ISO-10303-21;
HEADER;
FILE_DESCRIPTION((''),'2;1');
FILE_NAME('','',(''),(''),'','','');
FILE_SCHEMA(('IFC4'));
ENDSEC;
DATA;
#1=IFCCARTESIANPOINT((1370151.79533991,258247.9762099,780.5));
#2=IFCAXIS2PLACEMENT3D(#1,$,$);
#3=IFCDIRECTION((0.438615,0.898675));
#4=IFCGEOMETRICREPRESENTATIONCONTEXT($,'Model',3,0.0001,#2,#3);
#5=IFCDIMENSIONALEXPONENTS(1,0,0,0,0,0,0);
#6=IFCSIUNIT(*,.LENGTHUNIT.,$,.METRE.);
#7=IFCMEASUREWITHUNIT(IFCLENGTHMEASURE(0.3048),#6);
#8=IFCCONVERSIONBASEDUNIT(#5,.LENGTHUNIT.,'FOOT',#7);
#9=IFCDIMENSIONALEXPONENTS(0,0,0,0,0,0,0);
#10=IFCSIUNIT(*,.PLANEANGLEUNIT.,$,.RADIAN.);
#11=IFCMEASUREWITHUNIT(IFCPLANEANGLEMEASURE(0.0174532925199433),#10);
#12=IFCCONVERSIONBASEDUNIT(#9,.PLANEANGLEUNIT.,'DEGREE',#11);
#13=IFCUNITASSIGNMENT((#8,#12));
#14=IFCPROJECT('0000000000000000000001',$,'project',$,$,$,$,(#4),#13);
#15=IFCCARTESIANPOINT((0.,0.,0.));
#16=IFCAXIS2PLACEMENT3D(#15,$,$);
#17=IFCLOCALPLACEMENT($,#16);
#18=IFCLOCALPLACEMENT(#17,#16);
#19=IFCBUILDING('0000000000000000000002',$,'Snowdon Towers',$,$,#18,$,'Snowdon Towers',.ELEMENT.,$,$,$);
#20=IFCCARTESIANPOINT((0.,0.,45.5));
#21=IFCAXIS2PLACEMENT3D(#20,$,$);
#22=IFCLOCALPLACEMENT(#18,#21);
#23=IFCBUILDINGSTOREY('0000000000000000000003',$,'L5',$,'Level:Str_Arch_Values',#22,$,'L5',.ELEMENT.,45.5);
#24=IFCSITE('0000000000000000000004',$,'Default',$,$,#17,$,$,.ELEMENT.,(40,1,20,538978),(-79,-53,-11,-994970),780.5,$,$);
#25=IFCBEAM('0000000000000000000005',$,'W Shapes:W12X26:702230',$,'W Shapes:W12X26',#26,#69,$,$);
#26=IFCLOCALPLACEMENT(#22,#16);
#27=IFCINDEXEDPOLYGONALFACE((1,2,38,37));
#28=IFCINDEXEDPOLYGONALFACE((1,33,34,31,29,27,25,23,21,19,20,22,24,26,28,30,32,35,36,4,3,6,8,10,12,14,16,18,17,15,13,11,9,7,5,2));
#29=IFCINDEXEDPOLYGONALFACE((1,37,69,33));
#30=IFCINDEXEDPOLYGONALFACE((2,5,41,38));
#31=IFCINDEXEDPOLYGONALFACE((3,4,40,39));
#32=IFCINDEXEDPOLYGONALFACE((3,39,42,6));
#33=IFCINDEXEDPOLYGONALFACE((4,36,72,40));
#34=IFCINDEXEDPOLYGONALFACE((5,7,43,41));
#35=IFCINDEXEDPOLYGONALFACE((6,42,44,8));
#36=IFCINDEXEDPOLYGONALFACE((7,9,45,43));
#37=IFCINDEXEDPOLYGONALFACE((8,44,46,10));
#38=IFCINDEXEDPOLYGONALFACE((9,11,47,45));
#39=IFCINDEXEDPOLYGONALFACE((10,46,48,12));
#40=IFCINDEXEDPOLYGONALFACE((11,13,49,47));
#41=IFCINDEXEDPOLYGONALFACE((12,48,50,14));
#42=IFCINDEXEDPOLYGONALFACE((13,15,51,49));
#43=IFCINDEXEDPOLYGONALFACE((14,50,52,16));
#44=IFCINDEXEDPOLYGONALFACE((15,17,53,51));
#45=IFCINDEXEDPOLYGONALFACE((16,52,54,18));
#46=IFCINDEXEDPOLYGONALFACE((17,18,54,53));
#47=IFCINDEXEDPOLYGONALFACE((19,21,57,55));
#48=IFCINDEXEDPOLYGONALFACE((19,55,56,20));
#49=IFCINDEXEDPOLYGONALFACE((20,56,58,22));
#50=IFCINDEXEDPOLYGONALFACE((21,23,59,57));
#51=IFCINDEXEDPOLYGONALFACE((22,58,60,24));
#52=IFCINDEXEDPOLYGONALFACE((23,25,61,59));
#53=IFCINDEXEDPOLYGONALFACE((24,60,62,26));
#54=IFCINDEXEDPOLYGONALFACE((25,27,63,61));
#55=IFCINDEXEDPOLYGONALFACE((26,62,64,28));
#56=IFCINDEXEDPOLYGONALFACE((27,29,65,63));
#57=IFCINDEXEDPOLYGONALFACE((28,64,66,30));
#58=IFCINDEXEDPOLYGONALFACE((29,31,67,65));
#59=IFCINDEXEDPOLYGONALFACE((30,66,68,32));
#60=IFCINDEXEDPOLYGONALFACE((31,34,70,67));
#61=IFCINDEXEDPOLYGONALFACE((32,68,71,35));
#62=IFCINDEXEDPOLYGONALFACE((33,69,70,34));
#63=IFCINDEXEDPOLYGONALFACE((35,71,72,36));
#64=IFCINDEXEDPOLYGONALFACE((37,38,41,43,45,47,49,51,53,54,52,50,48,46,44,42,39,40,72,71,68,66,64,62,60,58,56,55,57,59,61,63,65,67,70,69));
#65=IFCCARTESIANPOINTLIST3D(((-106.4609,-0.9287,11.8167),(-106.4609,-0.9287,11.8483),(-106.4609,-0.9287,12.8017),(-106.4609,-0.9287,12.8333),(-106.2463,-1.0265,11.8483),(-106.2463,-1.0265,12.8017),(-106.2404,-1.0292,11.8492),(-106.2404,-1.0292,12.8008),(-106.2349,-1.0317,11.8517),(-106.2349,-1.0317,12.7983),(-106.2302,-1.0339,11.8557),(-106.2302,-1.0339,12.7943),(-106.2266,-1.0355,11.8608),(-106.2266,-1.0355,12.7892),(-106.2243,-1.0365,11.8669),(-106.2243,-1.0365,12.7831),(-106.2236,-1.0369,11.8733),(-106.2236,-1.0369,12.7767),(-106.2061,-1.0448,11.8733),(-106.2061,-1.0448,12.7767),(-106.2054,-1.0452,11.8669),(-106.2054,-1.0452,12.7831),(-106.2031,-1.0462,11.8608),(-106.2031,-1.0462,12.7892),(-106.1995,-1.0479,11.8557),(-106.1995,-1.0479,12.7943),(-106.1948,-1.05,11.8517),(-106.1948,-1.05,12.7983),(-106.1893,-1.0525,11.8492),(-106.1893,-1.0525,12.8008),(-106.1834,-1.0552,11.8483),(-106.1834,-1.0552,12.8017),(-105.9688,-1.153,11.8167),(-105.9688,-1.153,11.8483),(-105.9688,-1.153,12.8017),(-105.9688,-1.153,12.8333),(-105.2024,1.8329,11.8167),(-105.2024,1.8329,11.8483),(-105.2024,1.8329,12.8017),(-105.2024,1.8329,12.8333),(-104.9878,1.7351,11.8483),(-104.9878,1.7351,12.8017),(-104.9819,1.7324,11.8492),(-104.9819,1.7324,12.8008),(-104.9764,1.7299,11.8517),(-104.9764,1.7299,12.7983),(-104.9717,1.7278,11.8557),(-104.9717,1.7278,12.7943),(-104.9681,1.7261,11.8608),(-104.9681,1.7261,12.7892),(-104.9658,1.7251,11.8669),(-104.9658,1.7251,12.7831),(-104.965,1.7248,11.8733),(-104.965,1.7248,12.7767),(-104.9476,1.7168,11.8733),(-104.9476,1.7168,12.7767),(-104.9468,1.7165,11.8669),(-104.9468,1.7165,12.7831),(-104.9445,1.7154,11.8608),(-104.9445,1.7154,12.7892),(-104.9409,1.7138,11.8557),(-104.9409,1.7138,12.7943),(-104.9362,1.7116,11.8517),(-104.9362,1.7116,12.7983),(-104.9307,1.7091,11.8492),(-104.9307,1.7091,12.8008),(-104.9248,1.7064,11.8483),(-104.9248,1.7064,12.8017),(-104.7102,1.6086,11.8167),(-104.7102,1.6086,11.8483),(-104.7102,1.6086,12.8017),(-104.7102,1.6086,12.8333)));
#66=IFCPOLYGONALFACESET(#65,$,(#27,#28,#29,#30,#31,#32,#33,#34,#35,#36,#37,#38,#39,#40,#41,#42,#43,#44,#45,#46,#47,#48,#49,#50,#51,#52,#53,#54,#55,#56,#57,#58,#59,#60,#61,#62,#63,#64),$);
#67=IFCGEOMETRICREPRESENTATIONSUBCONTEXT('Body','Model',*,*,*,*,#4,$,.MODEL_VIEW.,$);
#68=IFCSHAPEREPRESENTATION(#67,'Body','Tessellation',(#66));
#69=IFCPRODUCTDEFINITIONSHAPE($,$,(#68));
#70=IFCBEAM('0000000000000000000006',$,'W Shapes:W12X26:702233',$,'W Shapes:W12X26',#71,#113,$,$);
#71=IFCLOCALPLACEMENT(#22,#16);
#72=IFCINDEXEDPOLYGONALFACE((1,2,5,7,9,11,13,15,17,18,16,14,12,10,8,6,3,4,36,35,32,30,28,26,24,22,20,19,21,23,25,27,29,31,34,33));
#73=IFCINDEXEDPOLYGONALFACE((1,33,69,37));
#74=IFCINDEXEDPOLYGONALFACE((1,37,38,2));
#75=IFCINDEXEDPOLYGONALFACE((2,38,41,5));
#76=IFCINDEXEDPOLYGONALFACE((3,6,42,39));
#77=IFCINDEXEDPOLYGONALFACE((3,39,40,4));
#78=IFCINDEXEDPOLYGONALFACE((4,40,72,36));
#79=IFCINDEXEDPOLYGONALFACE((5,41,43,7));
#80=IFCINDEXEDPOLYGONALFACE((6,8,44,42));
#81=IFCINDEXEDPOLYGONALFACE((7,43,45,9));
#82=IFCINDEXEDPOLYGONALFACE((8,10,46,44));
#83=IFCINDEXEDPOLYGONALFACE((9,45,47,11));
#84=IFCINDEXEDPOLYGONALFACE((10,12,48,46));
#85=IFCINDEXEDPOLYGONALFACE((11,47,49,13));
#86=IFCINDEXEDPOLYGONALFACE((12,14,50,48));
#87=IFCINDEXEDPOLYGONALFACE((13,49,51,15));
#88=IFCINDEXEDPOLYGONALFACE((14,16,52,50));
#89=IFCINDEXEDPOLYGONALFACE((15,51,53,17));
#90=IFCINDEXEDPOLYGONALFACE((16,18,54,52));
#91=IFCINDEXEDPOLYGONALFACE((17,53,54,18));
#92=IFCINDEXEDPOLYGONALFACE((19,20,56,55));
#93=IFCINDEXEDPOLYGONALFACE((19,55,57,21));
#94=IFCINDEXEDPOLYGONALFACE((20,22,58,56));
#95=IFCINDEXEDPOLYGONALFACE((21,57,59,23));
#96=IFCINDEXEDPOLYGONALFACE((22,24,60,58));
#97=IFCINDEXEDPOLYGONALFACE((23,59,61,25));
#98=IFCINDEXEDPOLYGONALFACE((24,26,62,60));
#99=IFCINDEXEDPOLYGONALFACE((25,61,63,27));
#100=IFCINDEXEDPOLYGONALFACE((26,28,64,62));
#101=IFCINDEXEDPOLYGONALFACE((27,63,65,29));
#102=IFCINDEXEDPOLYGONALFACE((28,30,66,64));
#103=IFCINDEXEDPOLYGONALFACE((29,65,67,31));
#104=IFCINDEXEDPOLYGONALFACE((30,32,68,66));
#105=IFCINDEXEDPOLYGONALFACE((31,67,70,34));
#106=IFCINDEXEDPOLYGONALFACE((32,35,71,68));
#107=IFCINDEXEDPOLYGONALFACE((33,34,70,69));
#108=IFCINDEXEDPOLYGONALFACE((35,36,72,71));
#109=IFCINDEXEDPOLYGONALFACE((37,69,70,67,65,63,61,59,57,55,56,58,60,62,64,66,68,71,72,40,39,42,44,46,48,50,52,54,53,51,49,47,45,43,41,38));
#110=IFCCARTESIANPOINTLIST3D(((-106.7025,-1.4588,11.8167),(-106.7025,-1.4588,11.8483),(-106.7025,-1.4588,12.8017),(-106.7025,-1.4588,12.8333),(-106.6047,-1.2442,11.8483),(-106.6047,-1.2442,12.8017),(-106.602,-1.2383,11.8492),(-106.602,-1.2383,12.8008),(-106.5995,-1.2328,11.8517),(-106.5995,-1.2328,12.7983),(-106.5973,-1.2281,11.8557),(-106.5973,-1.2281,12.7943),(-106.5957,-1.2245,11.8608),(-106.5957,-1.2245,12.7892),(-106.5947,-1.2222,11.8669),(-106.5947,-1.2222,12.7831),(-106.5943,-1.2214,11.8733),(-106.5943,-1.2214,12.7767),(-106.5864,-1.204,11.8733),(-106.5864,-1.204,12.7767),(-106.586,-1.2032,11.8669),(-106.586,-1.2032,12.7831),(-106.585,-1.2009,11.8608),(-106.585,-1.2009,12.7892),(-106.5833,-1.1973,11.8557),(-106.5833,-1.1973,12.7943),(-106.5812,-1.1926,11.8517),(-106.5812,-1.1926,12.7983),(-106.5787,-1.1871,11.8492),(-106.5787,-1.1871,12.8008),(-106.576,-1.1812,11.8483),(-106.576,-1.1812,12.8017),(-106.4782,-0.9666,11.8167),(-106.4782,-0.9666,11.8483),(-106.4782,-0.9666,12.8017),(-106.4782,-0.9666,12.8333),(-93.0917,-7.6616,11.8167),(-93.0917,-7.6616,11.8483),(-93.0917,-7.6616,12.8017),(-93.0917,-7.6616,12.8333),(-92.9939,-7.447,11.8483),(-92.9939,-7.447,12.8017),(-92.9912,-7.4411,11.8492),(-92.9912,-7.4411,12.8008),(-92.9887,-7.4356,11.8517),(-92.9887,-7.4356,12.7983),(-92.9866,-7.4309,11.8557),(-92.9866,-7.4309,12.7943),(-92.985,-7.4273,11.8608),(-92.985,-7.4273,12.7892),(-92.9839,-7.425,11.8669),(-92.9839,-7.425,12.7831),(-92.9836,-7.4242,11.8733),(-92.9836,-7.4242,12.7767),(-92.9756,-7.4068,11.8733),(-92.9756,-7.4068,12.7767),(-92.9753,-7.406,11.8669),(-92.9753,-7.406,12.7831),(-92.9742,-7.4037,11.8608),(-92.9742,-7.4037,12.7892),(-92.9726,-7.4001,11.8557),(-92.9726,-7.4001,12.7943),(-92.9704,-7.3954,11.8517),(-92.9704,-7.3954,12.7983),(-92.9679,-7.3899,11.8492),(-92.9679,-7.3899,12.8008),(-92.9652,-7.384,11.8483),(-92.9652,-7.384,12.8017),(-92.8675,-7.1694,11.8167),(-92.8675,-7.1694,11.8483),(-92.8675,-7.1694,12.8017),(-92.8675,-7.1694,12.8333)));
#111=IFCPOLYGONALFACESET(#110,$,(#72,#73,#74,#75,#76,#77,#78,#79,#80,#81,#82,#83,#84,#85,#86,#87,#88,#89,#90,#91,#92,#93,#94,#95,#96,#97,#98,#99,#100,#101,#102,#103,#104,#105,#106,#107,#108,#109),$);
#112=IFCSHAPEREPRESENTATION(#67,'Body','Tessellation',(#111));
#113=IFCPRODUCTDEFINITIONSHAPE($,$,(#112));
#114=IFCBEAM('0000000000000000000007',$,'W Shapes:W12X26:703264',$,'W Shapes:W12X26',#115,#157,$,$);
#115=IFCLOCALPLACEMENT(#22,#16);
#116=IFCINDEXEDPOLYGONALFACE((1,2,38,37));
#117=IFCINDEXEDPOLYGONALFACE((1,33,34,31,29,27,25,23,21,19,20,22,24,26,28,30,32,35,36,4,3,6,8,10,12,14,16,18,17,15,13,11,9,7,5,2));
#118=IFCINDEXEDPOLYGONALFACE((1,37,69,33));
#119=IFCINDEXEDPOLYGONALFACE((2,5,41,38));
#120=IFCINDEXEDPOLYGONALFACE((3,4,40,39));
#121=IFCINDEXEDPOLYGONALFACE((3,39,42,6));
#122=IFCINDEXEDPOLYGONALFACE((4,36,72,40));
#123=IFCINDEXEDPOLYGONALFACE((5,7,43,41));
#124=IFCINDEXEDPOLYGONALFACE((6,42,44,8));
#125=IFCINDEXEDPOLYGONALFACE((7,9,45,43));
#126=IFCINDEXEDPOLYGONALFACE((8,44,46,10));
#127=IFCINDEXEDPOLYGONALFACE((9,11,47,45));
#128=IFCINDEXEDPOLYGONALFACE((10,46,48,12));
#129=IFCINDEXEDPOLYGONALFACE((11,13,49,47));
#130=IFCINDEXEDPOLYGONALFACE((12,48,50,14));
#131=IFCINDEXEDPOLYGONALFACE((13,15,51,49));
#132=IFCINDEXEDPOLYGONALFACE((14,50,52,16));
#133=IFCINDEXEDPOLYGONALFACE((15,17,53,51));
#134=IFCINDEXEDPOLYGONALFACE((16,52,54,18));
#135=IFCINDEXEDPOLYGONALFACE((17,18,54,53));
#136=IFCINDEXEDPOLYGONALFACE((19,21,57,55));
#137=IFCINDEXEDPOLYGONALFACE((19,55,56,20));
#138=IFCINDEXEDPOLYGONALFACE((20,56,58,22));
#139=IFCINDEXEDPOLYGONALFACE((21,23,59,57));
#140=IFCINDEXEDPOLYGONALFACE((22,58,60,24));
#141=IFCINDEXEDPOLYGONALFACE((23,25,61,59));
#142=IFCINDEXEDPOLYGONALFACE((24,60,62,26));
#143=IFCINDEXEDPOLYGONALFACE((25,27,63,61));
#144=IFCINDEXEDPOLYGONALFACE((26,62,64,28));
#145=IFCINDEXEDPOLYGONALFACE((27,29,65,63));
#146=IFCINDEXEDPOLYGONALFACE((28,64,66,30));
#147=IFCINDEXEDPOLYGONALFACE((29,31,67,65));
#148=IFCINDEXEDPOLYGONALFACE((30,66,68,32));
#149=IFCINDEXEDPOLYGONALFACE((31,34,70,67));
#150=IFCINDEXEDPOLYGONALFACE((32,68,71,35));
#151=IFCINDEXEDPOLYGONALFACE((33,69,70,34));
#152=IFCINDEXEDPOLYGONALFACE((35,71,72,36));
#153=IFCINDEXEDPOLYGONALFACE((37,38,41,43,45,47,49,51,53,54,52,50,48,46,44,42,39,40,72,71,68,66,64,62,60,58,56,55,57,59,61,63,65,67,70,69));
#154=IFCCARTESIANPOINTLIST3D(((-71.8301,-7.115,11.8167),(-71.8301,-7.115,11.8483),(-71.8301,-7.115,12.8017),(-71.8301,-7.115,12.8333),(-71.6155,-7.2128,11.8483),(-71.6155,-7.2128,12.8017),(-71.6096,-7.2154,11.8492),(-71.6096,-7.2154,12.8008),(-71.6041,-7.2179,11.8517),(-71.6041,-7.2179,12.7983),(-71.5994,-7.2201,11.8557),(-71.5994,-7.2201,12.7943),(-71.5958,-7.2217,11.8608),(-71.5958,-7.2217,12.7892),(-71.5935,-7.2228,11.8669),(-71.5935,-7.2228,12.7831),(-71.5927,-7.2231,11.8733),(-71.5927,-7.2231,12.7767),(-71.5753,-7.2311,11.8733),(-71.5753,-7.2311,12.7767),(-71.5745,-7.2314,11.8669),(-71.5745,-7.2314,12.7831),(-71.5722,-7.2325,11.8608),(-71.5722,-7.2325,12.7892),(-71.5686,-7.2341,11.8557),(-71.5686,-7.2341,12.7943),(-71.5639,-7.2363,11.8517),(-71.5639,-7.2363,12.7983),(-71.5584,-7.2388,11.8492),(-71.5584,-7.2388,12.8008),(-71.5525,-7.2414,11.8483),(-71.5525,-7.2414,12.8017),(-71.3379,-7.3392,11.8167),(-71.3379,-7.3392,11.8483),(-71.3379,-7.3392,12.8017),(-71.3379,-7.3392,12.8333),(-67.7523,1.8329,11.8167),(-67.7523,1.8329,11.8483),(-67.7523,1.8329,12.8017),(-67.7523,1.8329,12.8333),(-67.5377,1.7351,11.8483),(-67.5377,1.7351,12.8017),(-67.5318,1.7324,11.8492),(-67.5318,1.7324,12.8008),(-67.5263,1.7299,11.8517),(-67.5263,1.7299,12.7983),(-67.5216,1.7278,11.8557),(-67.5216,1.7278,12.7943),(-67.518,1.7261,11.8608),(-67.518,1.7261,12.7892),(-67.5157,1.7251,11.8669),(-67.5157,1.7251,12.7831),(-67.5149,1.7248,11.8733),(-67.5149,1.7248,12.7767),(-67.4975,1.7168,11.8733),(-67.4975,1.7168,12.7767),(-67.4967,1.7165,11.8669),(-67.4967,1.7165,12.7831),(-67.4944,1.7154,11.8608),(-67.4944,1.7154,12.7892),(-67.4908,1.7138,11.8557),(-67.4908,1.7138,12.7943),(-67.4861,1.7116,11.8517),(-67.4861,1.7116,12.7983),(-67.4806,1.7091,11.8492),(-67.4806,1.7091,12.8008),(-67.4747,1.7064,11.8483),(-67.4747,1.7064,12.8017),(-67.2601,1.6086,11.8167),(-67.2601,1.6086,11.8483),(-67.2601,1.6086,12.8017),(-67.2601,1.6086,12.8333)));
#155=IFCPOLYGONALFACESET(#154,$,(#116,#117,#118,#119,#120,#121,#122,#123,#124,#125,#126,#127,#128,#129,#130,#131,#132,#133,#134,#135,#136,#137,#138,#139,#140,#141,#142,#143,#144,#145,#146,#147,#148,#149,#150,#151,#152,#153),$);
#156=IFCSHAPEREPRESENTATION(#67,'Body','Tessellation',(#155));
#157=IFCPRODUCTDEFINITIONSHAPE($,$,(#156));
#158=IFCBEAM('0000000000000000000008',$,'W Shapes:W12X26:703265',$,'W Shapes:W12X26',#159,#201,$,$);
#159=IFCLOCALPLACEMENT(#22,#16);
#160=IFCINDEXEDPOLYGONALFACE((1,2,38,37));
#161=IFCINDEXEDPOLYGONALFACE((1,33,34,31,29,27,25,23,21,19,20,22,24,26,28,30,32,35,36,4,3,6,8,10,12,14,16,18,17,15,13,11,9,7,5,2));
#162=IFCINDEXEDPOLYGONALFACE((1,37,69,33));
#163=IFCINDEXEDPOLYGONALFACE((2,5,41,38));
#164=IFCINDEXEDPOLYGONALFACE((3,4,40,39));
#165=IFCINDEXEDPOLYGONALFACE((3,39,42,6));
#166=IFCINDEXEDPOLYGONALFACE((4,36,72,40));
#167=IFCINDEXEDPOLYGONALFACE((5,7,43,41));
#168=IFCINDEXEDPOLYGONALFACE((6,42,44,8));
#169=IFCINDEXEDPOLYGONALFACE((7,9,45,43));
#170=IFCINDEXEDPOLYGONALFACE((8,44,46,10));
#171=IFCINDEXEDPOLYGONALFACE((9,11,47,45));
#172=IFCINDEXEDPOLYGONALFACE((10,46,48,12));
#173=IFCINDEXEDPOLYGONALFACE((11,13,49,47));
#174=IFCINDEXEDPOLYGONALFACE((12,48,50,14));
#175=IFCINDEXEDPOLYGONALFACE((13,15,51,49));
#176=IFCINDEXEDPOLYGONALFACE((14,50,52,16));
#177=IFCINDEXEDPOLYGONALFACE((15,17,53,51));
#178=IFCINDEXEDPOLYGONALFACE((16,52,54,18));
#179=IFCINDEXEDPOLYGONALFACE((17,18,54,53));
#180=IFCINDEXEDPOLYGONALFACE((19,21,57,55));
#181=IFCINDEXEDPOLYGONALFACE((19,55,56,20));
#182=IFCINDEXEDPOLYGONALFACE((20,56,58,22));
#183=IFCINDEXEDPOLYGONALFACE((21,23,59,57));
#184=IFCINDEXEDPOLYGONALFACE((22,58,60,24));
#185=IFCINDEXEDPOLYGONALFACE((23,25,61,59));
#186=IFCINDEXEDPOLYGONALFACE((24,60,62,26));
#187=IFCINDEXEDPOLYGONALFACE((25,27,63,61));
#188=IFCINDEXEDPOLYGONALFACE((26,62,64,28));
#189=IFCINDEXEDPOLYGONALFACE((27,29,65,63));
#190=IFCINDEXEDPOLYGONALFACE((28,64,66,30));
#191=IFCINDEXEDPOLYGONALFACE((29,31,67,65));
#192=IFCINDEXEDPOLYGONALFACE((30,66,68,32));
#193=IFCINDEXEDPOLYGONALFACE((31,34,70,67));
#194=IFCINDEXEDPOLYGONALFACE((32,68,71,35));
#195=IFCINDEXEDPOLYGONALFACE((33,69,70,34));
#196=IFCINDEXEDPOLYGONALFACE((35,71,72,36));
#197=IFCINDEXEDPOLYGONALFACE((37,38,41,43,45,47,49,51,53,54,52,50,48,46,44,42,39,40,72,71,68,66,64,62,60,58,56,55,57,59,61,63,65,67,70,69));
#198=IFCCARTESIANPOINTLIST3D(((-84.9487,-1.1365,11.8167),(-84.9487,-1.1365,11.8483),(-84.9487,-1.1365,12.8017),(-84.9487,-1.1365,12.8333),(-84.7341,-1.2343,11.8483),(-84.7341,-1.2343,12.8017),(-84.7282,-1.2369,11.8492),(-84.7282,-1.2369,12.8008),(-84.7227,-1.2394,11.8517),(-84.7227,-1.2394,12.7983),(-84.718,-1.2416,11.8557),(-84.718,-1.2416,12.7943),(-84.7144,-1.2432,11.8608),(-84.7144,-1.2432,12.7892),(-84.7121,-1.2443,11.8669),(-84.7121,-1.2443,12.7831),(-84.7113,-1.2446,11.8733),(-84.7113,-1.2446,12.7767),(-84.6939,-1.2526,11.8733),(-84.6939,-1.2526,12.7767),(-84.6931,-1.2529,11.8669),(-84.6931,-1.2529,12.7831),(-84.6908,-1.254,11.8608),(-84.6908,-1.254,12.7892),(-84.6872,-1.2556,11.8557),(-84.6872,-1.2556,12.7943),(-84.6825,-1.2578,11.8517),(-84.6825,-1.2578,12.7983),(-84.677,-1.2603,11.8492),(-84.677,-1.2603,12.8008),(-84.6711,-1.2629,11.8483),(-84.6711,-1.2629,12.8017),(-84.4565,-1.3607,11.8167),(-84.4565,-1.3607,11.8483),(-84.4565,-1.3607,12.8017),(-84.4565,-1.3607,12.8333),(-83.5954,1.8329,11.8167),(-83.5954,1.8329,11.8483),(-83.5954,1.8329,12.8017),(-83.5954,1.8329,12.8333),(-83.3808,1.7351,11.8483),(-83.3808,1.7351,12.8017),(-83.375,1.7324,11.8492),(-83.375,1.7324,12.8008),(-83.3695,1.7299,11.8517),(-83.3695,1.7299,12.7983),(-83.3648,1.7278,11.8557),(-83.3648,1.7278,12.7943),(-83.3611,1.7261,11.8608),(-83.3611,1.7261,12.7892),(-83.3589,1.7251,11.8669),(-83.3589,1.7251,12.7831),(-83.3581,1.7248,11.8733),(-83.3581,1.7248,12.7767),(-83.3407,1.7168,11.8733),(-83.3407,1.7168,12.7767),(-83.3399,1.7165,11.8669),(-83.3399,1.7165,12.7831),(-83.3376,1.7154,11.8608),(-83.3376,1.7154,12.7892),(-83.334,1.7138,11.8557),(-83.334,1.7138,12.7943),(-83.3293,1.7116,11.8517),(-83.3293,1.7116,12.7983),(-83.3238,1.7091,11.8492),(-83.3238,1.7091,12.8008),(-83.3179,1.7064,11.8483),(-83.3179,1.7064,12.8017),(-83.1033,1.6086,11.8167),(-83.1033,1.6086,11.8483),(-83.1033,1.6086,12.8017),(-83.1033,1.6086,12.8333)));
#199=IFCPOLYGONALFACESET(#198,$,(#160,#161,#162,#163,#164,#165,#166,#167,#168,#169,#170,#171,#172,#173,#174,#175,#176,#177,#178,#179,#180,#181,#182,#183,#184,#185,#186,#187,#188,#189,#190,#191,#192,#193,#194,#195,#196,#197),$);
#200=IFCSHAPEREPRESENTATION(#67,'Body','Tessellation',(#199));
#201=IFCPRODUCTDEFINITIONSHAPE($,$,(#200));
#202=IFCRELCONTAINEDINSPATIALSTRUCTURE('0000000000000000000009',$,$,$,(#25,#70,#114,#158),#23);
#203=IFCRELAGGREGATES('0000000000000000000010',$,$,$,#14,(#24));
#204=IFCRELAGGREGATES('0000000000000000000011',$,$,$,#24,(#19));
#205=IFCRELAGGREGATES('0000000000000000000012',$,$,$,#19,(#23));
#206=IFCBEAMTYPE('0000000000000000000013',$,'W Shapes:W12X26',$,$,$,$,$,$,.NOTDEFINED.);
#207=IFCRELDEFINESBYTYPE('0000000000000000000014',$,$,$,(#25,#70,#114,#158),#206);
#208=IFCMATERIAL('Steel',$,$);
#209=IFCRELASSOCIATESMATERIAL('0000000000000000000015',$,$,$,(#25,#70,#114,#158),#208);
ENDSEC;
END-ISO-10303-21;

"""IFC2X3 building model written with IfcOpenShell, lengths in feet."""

from ifc_helpers import new_model, entity, si_unit, converted_unit, direction, frame, frame_2d, origin, place, context, subcontext, project, spatial, i_section, extrude, material, type_object, element, save


model = new_model("IFC2X3")

# Units and contexts
model_context = context("Model", 3, precision=0.0001, world=frame((1370151.79533991, 258247.9762099, 780.5)), true_north=direction((0.438615, 0.898675)))
body_context = subcontext(model_context, "Body", "Model", "MODEL_VIEW")
ifc_project = project(units=[converted_unit("LENGTHUNIT", "FOOT", entity("IfcLengthMeasure", 0.3048), si_unit("LENGTHUNIT", "METRE"), dimensions=[1, 0, 0, 0, 0, 0, 0]), converted_unit("PLANEANGLEUNIT", "DEGREE", entity("IfcPlaneAngleMeasure", 0.0174532925199433), si_unit("PLANEANGLEUNIT", "RADIAN"), dimensions=[0, 0, 0, 0, 0, 0, 0])], contexts=[model_context])

# Site, building, storey
site_placement = place(None, origin())
site = spatial("IfcSite", under=ifc_project, at=site_placement, Name="Default", CompositionType="ELEMENT", RefLatitude=(40, 1, 20, 538978), RefLongitude=(-79, -53, -11, -994970), RefElevation=780.5)
building_placement = place(site_placement, origin())
building = spatial("IfcBuilding", under=site, at=building_placement, Name="Snowdon Towers", LongName="Snowdon Towers", CompositionType="ELEMENT")
storey_placement = place(building_placement, frame((0.0, 0.0, 45.5)))
storey = spatial("IfcBuildingStorey", under=building, at=storey_placement, Name="L5", ObjectType="Level:Str_Arch_Values", LongName="L5", CompositionType="ELEMENT", Elevation=45.5)

# Shared definitions
ifc_material = material(Name="Steel")

# Beams
beam_type_1 = type_object("IfcBeamType", Name="W Shapes:W12X26", PredefinedType="NOTDEFINED")
beam_1_placement = place(storey_placement, frame((-106.3443, -1.3248, 12.8333), z_axis=(0.0, 0.0, 1.0), x_axis=(0.414693, 0.909961, 0.0)))
element("IfcBeam", 1, at=beam_1_placement, inside=storey, type_object=beam_type_1, material=ifc_material, Name="W Shapes:W12X26:702230", ObjectType="W Shapes:W12X26", context=body_context, shape_type="SweptSolid", body=[
    extrude(i_section(OverallWidth=0.5408, OverallDepth=1.0167, WebThickness=0.0192, FlangeThickness=0.0317, FilletRadius=0.025, at=frame_2d((0.0, 0.0), x_axis=(0.0, 1.0))), frame((0.3121, 0.0, -0.5083), z_axis=(1.0, 0.0, 0.0), x_axis=(0.0, 0.0, -1.0)), (0.0, 0.0, 1.0), 3.0349),
])
beam_2_placement = place(storey_placement, frame((-106.3443, -1.3248, 12.8333), z_axis=(0.0, 0.0, 1.0), x_axis=(0.909961, -0.414693, 0.0)))
element("IfcBeam", 2, at=beam_2_placement, inside=storey, type_object=beam_type_1, material=ifc_material, Name="W Shapes:W12X26:702233", ObjectType="W Shapes:W12X26", context=body_context, shape_type="SweptSolid", body=[
    extrude(i_section(OverallWidth=0.5408, OverallDepth=1.0167, WebThickness=0.0192, FlangeThickness=0.0317, FilletRadius=0.025, at=frame_2d((0.0, 0.0), x_axis=(0.0, 1.0))), frame((-0.2704, 0.0, -0.5083), z_axis=(1.0, 0.0, 0.0), x_axis=(0.0, 0.0, -1.0)), (0.0, 0.0, 1.0), 14.9575),
])
beam_3_placement = place(storey_placement, frame((-71.7134, -7.5111, 12.8333), z_axis=(0.0, 0.0, 1.0), x_axis=(0.414693, 0.909961, 0.0)))
element("IfcBeam", 3, at=beam_3_placement, inside=storey, type_object=beam_type_1, material=ifc_material, Name="W Shapes:W12X26:703264", ObjectType="W Shapes:W12X26", context=body_context, shape_type="SweptSolid", body=[
    extrude(i_section(OverallWidth=0.5408, OverallDepth=1.0167, WebThickness=0.0192, FlangeThickness=0.0317, FilletRadius=0.025, at=frame_2d((0.0, 0.0), x_axis=(0.0, 1.0))), frame((0.3121, 0.0, -0.5083), z_axis=(1.0, 0.0, 0.0), x_axis=(0.0, 0.0, -1.0)), (0.0, 0.0, 1.0), 9.8332),
])
beam_4_placement = place(storey_placement, frame((-84.832, -1.5326, 12.8333), z_axis=(0.0, 0.0, 1.0), x_axis=(0.414693, 0.909961, 0.0)))
element("IfcBeam", 4, at=beam_4_placement, inside=storey, type_object=beam_type_1, material=ifc_material, Name="W Shapes:W12X26:703265", ObjectType="W Shapes:W12X26", context=body_context, shape_type="SweptSolid", body=[
    extrude(i_section(OverallWidth=0.5408, OverallDepth=1.0167, WebThickness=0.0192, FlangeThickness=0.0317, FilletRadius=0.025, at=frame_2d((0.0, 0.0), x_axis=(0.0, 1.0))), frame((0.3121, 0.0, -0.5083), z_axis=(1.0, 0.0, 0.0), x_axis=(0.0, 0.0, -1.0)), (0.0, 0.0, 1.0), 3.2632),
])

save(model, "model.ifc")
